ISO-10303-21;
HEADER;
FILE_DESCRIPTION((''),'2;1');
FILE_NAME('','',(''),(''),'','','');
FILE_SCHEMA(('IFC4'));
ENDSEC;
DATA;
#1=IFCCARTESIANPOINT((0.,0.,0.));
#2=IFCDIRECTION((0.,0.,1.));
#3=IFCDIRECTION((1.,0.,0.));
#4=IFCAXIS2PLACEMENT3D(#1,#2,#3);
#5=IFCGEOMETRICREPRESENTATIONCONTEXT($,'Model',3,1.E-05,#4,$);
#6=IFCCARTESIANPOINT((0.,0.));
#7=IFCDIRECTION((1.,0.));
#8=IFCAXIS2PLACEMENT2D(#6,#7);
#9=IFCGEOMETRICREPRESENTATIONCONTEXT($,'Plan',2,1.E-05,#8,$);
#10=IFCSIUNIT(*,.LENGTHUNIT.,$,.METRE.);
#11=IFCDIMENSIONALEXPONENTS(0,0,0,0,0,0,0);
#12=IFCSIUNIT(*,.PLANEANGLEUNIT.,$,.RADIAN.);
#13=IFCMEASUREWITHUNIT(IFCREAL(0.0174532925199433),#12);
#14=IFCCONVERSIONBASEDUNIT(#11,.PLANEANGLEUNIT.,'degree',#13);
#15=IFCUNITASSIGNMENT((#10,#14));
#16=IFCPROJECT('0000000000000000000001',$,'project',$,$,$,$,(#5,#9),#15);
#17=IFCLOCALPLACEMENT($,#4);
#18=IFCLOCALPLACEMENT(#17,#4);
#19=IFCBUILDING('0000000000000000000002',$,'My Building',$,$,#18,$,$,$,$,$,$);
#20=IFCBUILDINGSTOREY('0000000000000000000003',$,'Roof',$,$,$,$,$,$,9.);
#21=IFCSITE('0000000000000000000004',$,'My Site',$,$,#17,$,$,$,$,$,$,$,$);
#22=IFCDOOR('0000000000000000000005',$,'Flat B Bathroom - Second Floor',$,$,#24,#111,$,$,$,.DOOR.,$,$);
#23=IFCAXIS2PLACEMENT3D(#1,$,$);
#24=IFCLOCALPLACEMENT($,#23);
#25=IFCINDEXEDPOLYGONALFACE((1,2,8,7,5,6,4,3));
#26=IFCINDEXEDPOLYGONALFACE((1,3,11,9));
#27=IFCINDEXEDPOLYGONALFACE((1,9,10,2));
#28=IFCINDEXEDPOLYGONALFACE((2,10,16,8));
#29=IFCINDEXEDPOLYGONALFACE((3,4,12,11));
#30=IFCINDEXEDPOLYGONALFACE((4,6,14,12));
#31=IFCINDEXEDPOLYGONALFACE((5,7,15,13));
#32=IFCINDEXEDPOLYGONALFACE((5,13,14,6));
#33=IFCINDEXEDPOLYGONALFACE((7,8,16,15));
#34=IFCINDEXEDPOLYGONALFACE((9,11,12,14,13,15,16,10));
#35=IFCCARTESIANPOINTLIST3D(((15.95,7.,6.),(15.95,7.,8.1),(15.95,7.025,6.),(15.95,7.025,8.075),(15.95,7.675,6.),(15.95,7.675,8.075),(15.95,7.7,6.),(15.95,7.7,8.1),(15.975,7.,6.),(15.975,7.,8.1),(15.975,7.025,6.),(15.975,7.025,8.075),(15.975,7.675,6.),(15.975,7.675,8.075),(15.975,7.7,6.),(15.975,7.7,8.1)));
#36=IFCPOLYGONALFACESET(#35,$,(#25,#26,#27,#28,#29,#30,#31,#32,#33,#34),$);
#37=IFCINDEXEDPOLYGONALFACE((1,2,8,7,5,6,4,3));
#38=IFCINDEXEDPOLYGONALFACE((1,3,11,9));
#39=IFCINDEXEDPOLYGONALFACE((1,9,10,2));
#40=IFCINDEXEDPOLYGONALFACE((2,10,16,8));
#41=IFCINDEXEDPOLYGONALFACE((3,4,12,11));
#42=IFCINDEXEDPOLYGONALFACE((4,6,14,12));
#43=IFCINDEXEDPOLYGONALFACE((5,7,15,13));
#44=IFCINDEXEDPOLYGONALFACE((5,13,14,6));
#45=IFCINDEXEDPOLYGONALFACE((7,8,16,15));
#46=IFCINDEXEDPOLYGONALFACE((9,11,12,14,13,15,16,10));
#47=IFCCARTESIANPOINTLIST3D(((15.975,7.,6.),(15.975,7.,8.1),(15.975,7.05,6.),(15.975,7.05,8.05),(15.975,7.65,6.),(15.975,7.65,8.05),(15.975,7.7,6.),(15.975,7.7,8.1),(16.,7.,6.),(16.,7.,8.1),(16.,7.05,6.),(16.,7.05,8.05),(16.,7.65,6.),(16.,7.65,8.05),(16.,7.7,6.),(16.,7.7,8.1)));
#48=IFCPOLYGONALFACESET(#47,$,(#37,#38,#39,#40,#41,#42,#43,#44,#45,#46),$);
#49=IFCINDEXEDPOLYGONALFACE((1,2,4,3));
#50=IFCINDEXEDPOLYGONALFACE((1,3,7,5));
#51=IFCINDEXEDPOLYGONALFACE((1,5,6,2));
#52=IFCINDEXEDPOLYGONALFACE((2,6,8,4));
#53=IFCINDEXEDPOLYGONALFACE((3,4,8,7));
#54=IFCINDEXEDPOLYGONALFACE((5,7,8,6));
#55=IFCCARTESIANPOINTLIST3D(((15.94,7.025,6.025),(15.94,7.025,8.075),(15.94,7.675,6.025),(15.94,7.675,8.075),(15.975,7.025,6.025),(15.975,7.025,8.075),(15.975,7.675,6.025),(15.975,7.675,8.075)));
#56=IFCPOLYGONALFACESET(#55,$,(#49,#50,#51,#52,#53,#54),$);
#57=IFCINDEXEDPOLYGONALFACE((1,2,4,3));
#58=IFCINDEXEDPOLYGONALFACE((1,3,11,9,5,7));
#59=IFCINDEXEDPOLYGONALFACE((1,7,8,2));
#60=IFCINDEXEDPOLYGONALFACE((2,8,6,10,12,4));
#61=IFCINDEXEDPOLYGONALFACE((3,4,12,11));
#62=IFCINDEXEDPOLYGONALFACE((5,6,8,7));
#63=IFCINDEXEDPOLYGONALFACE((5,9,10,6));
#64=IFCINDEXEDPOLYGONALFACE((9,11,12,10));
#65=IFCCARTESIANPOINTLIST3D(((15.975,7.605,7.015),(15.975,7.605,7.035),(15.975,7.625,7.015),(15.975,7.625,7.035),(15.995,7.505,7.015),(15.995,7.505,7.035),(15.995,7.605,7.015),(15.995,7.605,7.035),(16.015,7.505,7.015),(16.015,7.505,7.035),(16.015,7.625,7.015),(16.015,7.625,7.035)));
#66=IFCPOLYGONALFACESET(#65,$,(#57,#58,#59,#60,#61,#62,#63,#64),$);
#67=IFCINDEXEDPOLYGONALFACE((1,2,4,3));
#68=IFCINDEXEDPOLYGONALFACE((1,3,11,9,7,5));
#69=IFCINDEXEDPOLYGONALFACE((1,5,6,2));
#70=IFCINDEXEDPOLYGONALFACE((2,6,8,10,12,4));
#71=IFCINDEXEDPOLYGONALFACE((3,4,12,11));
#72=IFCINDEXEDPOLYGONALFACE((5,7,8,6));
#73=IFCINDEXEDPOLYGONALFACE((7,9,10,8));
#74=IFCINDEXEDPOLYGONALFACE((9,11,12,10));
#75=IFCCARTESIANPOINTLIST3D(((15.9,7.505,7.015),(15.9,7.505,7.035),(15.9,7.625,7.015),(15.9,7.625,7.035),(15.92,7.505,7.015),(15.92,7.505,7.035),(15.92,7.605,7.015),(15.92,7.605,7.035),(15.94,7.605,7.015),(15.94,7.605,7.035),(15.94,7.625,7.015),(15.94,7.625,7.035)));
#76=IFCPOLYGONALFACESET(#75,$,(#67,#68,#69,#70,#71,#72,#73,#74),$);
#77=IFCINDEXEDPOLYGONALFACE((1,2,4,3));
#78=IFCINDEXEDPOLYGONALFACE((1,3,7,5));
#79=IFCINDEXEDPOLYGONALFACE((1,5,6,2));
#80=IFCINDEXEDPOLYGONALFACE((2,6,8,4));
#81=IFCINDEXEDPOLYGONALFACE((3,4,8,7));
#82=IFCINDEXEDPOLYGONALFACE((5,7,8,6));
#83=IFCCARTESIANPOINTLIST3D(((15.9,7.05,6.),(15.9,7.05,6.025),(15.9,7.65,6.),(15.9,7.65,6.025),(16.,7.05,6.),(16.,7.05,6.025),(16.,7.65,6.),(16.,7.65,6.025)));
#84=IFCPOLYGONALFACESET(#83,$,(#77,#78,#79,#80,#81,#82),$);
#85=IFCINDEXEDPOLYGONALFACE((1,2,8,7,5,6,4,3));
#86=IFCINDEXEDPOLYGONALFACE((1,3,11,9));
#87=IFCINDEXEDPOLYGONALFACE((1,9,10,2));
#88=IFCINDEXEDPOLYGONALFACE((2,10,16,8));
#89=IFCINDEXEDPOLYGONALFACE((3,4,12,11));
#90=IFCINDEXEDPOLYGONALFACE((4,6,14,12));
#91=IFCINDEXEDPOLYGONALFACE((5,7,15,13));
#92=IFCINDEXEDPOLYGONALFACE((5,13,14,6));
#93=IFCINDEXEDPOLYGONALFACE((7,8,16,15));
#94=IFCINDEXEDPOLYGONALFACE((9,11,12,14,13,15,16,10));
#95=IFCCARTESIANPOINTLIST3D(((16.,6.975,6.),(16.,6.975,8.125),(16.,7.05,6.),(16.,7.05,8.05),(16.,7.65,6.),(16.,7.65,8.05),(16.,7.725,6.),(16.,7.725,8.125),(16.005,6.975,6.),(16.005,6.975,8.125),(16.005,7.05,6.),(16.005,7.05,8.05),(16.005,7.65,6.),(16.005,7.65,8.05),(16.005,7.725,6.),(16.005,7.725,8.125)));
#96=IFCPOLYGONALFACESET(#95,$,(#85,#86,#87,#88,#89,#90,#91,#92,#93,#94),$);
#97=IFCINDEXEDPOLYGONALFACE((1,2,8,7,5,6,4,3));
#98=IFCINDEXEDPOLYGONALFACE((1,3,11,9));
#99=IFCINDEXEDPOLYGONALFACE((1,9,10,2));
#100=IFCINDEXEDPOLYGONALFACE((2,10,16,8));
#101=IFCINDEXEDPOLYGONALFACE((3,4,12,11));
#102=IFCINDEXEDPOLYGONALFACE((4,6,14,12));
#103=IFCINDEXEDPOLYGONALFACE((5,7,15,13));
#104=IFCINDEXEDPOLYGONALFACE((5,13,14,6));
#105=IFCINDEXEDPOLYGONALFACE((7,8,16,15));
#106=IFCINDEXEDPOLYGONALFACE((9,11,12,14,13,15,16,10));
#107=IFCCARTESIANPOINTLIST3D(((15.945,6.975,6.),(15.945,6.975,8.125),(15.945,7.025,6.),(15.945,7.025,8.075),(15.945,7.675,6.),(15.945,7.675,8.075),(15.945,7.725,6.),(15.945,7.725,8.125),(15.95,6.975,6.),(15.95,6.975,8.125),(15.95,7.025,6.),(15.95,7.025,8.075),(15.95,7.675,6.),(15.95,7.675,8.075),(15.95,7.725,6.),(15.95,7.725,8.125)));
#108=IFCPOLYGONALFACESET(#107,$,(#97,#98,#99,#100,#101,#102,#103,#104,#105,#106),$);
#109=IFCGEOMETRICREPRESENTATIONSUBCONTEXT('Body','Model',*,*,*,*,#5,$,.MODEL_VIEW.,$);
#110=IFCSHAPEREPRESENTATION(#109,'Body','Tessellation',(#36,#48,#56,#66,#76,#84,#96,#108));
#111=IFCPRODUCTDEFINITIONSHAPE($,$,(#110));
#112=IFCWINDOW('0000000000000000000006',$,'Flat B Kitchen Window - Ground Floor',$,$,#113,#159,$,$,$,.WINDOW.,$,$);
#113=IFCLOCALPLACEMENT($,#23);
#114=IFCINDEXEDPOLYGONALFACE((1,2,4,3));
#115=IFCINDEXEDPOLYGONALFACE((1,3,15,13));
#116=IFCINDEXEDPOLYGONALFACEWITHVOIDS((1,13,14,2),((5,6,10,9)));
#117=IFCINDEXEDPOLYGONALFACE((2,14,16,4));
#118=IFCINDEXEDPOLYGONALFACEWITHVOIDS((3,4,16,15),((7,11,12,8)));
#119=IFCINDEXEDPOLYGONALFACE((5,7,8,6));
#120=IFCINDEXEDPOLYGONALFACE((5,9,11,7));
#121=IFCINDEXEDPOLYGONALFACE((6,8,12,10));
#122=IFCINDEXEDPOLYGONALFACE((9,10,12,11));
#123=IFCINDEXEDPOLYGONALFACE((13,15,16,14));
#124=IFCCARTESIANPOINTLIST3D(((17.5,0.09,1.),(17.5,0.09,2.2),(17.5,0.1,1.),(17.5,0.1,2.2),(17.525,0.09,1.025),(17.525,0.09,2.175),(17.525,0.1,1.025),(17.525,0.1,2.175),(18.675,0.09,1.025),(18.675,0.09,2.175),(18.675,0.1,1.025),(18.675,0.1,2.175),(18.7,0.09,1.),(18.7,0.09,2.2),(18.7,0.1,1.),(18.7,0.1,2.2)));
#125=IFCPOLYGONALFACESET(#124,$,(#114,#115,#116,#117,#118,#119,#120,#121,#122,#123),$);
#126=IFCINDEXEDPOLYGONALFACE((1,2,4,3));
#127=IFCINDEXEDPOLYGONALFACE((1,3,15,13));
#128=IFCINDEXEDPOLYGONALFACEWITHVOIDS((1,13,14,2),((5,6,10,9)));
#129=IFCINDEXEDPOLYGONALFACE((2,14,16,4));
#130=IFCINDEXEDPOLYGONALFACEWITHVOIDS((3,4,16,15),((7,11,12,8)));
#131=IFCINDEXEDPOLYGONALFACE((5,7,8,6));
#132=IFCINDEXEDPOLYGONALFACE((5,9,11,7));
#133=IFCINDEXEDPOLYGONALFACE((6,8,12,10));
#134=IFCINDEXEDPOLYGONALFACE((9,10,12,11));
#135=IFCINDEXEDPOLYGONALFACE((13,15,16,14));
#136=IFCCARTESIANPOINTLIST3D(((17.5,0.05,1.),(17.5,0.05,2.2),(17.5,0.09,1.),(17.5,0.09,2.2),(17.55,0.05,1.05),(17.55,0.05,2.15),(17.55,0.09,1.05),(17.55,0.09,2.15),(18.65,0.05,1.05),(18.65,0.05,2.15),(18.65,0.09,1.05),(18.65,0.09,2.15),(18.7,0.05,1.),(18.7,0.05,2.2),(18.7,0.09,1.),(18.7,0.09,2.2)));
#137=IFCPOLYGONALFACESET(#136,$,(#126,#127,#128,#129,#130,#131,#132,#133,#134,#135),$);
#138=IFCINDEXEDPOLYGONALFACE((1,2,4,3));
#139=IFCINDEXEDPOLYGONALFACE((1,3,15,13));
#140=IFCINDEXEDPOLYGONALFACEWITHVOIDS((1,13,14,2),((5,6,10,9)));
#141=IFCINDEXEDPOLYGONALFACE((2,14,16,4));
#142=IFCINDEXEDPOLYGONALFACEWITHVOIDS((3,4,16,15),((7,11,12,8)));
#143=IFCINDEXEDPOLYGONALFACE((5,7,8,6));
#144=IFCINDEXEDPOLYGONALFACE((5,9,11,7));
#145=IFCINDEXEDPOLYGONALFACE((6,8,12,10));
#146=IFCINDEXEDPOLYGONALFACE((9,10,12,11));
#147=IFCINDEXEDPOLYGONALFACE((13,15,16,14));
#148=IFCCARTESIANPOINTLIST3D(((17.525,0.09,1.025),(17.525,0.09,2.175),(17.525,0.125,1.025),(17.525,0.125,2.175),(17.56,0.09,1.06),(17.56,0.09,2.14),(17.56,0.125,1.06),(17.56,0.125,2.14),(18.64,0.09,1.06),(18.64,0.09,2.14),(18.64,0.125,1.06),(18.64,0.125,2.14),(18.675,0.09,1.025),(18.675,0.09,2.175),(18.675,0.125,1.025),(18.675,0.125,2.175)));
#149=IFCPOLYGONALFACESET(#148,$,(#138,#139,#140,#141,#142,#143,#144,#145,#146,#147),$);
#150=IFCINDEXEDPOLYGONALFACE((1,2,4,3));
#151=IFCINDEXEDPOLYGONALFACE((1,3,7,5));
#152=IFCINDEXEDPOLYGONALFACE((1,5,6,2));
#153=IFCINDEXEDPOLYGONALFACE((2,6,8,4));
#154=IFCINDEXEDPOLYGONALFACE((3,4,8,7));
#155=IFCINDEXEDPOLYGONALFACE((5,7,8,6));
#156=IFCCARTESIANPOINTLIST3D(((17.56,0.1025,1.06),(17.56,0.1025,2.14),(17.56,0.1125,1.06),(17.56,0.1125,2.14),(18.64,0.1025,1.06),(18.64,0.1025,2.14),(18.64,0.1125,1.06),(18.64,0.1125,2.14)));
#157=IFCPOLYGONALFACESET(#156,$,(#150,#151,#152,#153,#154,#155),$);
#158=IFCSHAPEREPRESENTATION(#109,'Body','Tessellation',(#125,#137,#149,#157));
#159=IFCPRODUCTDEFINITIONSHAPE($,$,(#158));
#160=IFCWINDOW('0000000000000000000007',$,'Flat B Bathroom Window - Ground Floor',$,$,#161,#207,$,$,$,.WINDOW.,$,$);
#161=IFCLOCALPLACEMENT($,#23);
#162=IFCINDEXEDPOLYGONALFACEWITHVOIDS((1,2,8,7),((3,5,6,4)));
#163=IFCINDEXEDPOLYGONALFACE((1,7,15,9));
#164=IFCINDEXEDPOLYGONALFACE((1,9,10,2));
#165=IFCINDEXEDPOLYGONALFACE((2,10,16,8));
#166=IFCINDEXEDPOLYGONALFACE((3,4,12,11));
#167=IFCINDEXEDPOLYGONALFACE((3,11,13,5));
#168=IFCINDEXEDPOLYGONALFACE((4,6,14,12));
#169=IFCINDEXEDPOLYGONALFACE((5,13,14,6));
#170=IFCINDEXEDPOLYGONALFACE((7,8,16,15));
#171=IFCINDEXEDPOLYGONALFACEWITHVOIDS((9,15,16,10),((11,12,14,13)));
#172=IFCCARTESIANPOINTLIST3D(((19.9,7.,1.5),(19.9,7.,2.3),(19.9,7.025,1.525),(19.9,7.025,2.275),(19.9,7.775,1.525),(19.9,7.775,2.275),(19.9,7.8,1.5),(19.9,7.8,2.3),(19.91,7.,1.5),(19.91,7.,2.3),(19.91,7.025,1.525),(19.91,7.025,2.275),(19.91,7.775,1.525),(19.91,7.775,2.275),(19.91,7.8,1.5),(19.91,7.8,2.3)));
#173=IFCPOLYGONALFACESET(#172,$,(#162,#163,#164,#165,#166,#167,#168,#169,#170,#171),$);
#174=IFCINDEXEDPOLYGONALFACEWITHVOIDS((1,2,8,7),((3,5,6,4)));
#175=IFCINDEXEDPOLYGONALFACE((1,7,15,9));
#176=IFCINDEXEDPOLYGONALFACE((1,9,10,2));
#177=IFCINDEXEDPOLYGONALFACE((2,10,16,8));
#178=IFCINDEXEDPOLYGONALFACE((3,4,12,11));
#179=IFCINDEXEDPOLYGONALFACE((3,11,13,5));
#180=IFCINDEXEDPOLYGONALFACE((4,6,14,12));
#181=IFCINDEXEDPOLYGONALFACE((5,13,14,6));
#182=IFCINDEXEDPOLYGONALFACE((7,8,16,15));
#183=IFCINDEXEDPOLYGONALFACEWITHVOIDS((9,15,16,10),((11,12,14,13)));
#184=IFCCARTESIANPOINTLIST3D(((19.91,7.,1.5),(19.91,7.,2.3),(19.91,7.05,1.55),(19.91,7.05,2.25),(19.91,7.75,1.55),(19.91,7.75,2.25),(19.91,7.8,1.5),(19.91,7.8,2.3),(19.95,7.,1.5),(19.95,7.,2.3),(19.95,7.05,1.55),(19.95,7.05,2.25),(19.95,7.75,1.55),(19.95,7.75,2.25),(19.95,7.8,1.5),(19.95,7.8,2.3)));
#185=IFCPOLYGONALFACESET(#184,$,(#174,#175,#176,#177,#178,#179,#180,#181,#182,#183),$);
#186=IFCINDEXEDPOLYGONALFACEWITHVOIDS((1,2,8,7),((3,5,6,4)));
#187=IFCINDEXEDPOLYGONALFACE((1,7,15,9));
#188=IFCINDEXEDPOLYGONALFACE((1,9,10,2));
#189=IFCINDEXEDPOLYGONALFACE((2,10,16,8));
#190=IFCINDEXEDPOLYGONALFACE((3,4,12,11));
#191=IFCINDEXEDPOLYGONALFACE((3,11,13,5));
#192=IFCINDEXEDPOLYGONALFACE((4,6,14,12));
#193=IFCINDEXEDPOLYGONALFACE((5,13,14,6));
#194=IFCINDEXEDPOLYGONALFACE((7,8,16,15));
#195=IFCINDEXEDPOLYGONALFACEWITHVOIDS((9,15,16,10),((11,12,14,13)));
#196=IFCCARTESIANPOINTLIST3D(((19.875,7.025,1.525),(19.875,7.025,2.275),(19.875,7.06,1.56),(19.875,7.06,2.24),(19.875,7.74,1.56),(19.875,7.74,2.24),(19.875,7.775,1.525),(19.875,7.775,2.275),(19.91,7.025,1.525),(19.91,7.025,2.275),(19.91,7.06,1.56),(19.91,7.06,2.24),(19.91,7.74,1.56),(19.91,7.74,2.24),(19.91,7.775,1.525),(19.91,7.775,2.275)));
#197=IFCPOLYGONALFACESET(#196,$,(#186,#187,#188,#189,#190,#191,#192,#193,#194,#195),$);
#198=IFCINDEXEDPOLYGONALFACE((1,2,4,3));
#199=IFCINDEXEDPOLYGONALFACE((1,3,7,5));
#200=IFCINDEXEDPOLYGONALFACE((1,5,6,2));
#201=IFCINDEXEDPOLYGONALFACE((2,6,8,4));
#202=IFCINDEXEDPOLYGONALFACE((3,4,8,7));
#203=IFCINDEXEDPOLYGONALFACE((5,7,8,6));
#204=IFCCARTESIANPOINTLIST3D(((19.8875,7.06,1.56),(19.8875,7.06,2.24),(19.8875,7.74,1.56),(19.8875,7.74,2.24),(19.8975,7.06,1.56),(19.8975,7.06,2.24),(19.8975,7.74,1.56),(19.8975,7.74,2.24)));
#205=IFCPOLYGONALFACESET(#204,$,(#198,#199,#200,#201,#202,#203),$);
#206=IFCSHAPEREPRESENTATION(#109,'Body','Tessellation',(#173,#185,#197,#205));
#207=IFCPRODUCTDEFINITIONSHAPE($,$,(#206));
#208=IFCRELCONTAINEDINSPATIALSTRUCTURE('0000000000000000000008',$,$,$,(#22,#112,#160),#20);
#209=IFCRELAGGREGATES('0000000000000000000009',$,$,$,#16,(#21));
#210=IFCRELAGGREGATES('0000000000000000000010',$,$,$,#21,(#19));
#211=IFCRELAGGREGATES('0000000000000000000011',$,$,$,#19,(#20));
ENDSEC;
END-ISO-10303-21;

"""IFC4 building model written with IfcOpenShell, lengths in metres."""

from ifc_helpers import new_model, entity, si_unit, converted_unit, frame, origin_with_axes, origin_2d_with_axis, place, context, subcontext, project, spatial, line, indexed_curve, outline, extrude, element, save


model = new_model("IFC4")

# Units and contexts
model_context = context("Model", 3, precision=1e-05, world=origin_with_axes())
plan_context = context("Plan", 2, precision=1e-05, world=origin_2d_with_axis())
body_context = subcontext(model_context, "Body", "Model", "MODEL_VIEW")
ifc_project = project(units=[si_unit("LENGTHUNIT", "METRE"), converted_unit("PLANEANGLEUNIT", "degree", entity("IfcReal", 0.0174532925199433), si_unit("PLANEANGLEUNIT", "RADIAN"), dimensions=[0, 0, 0, 0, 0, 0, 0])], contexts=[model_context, plan_context])

# Site, building, storey
site_placement = place(None, origin_with_axes())
site = spatial("IfcSite", under=ifc_project, at=site_placement, Name="My Site")
building_placement = place(site_placement, origin_with_axes())
building = spatial("IfcBuilding", under=site, at=building_placement, Name="My Building")
storey = spatial("IfcBuildingStorey", under=building, Name="Roof", Elevation=9.0)

# Door
door_1_placement = place(None, frame((16.0, 7.0, 6.0), z_axis=(0.0, 0.0, 1.0), x_axis=(0.0, 1.0, 0.0)))
element("IfcDoor", 1, at=door_1_placement, inside=storey, Name="Flat B Bathroom - Second Floor", PredefinedType="DOOR", context=body_context, shape_type="SweptSolid", body=[
    extrude(outline(indexed_curve([(0.0, 0.0), (0.0, 2.1), (0.7, 2.1), (0.7, 0.0), (0.675, 0.0), (0.675, 2.075), (0.025, 2.075), (0.025, 0.0)], segments=[line(1, 2, 3, 4, 5, 6, 7, 8, 1)])), frame((0.0, 0.025, 0.0), z_axis=(0.0, -1.0, 0.0), x_axis=(1.0, 0.0, 0.0)), (0.0, 0.0, -1.0), 0.025),
    extrude(outline(indexed_curve([(0.0, 0.0), (0.0, 2.1), (0.7, 2.1), (0.7, 0.0), (0.65, 0.0), (0.65, 2.05), (0.05, 2.05), (0.05, 0.0)], segments=[line(1, 2, 3, 4, 5, 6, 7, 8, 1)])), frame((0.0, 0.0, 0.0), z_axis=(0.0, -1.0, 0.0), x_axis=(1.0, 0.0, 0.0)), (0.0, 0.0, -1.0), 0.025),
    extrude(outline(indexed_curve([(0.0, 0.0), (0.65, 0.0), (0.65, 0.035), (0.0, 0.035)], segments=[line(1, 2, 3, 4, 1)])), frame((0.025, 0.025, 0.025), z_axis=(0.0, 0.0, 1.0), x_axis=(1.0, 0.0, 0.0)), (0.0, 0.0, 1.0), 2.05),
    extrude(outline(indexed_curve([(0.0, 0.0), (0.0, -0.04), (-0.12, -0.04), (-0.12, -0.02), (-0.02, -0.02), (-0.02, 0.0)], segments=[line(1, 2, 3, 4, 5, 6, 1)])), frame((0.625, 0.025, 1.015), z_axis=(0.0, 0.0, 1.0), x_axis=(1.0, 0.0, 0.0)), (0.0, 0.0, 1.0), 0.02),
    extrude(outline(indexed_curve([(0.0, 0.0), (0.0, 0.04), (-0.12, 0.04), (-0.12, 0.02), (-0.02, 0.02), (-0.02, 0.0)], segments=[line(1, 2, 3, 4, 5, 6, 1)])), frame((0.625, 0.06, 1.015), z_axis=(0.0, 0.0, 1.0), x_axis=(1.0, 0.0, 0.0)), (0.0, 0.0, 1.0), 0.02),
    extrude(outline(indexed_curve([(0.0, 0.0), (0.6, 0.0), (0.6, 0.1), (0.0, 0.1)], segments=[line(1, 2, 3, 4, 1)])), frame((0.05, 0.0, 0.0), z_axis=(0.0, 0.0, 1.0), x_axis=(1.0, 0.0, 0.0)), (0.0, 0.0, 1.0), 0.025),
    extrude(outline(indexed_curve([(0.0, 0.0), (0.0, 2.125), (0.75, 2.125), (0.75, 0.0), (0.675, 0.0), (0.675, 2.05), (0.075, 2.05), (0.075, 0.0)], segments=[line(1, 2, 3, 4, 5, 6, 7, 8, 1)])), frame((-0.025, -0.005, 0.0), z_axis=(0.0, -1.0, 0.0), x_axis=(1.0, 0.0, 0.0)), (0.0, 0.0, -1.0), 0.005),
    extrude(outline(indexed_curve([(0.0, 0.0), (0.0, 2.125), (0.75, 2.125), (0.75, 0.0), (0.7, 0.0), (0.7, 2.075), (0.05, 2.075), (0.05, 0.0)], segments=[line(1, 2, 3, 4, 5, 6, 7, 8, 1)])), frame((-0.025, 0.05, 0.0), z_axis=(0.0, -1.0, 0.0), x_axis=(1.0, 0.0, 0.0)), (0.0, 0.0, -1.0), 0.005),
])

# Windows
window_1_placement = place(None, frame((17.5, 0.0, 1.0), z_axis=(0.0, 0.0, 1.0), x_axis=(1.0, 0.0, 0.0)))
element("IfcWindow", 2, at=window_1_placement, inside=storey, Name="Flat B Kitchen Window - Ground Floor", PredefinedType="WINDOW", context=body_context, shape_type="SweptSolid", body=[
    extrude(outline(indexed_curve([(0.0, 0.0), (1.2, 0.0), (1.2, 1.2), (0.0, 1.2)], segments=[line(1, 2, 3, 4, 1)]), holes=[indexed_curve([(0.025, 0.025), (1.175, 0.025), (1.175, 1.175), (0.025, 1.175)], segments=[line(1, 2, 3, 4, 1)])]), frame((0.0, 0.09, 0.0), z_axis=(0.0, -1.0, 0.0), x_axis=(1.0, 0.0, 0.0)), (0.0, 0.0, -1.0), 0.01),
    extrude(outline(indexed_curve([(0.0, 0.0), (1.2, 0.0), (1.2, 1.2), (0.0, 1.2)], segments=[line(1, 2, 3, 4, 1)]), holes=[indexed_curve([(0.05, 0.05), (1.15, 0.05), (1.15, 1.15), (0.05, 1.15)], segments=[line(1, 2, 3, 4, 1)])]), frame((0.0, 0.05, 0.0), z_axis=(0.0, -1.0, 0.0), x_axis=(1.0, 0.0, 0.0)), (0.0, 0.0, -1.0), 0.04),
    extrude(outline(indexed_curve([(0.0, 0.0), (1.15, 0.0), (1.15, 1.15), (0.0, 1.15)], segments=[line(1, 2, 3, 4, 1)]), holes=[indexed_curve([(0.035, 0.035), (1.115, 0.035), (1.115, 1.115), (0.035, 1.115)], segments=[line(1, 2, 3, 4, 1)])]), frame((0.025, 0.09, 0.025), z_axis=(0.0, -1.0, 0.0), x_axis=(1.0, 0.0, 0.0)), (0.0, 0.0, -1.0), 0.035),
    extrude(outline(indexed_curve([(0.035, 0.035), (1.115, 0.035), (1.115, 1.115), (0.035, 1.115)], segments=[line(1, 2, 3, 4, 1)])), frame((0.025, 0.1025, 0.025), z_axis=(0.0, -1.0, 0.0), x_axis=(1.0, 0.0, 0.0)), (0.0, 0.0, -1.0), 0.01),
])
window_2_placement = place(None, frame((20.0, 7.0, 1.5), z_axis=(0.0, 0.0, 1.0), x_axis=(0.0, 1.0, 0.0)))
element("IfcWindow", 3, at=window_2_placement, inside=storey, Name="Flat B Bathroom Window - Ground Floor", PredefinedType="WINDOW", context=body_context, shape_type="SweptSolid", body=[
    extrude(outline(indexed_curve([(0.0, 0.0), (0.8, 0.0), (0.8, 0.8), (0.0, 0.8)], segments=[line(1, 2, 3, 4, 1)]), holes=[indexed_curve([(0.025, 0.025), (0.775, 0.025), (0.775, 0.775), (0.025, 0.775)], segments=[line(1, 2, 3, 4, 1)])]), frame((0.0, 0.09, 0.0), z_axis=(0.0, -1.0, 0.0), x_axis=(1.0, 0.0, 0.0)), (0.0, 0.0, -1.0), 0.01),
    extrude(outline(indexed_curve([(0.0, 0.0), (0.8, 0.0), (0.8, 0.8), (0.0, 0.8)], segments=[line(1, 2, 3, 4, 1)]), holes=[indexed_curve([(0.05, 0.05), (0.75, 0.05), (0.75, 0.75), (0.05, 0.75)], segments=[line(1, 2, 3, 4, 1)])]), frame((0.0, 0.05, 0.0), z_axis=(0.0, -1.0, 0.0), x_axis=(1.0, 0.0, 0.0)), (0.0, 0.0, -1.0), 0.04),
    extrude(outline(indexed_curve([(0.0, 0.0), (0.75, 0.0), (0.75, 0.75), (0.0, 0.75)], segments=[line(1, 2, 3, 4, 1)]), holes=[indexed_curve([(0.035, 0.035), (0.715, 0.035), (0.715, 0.715), (0.035, 0.715)], segments=[line(1, 2, 3, 4, 1)])]), frame((0.025, 0.09, 0.025), z_axis=(0.0, -1.0, 0.0), x_axis=(1.0, 0.0, 0.0)), (0.0, 0.0, -1.0), 0.035),
    extrude(outline(indexed_curve([(0.035, 0.035), (0.715, 0.035), (0.715, 0.715), (0.035, 0.715)], segments=[line(1, 2, 3, 4, 1)])), frame((0.025, 0.1025, 0.025), z_axis=(0.0, -1.0, 0.0), x_axis=(1.0, 0.0, 0.0)), (0.0, 0.0, -1.0), 0.01),
])

save(model, "model.ifc")
